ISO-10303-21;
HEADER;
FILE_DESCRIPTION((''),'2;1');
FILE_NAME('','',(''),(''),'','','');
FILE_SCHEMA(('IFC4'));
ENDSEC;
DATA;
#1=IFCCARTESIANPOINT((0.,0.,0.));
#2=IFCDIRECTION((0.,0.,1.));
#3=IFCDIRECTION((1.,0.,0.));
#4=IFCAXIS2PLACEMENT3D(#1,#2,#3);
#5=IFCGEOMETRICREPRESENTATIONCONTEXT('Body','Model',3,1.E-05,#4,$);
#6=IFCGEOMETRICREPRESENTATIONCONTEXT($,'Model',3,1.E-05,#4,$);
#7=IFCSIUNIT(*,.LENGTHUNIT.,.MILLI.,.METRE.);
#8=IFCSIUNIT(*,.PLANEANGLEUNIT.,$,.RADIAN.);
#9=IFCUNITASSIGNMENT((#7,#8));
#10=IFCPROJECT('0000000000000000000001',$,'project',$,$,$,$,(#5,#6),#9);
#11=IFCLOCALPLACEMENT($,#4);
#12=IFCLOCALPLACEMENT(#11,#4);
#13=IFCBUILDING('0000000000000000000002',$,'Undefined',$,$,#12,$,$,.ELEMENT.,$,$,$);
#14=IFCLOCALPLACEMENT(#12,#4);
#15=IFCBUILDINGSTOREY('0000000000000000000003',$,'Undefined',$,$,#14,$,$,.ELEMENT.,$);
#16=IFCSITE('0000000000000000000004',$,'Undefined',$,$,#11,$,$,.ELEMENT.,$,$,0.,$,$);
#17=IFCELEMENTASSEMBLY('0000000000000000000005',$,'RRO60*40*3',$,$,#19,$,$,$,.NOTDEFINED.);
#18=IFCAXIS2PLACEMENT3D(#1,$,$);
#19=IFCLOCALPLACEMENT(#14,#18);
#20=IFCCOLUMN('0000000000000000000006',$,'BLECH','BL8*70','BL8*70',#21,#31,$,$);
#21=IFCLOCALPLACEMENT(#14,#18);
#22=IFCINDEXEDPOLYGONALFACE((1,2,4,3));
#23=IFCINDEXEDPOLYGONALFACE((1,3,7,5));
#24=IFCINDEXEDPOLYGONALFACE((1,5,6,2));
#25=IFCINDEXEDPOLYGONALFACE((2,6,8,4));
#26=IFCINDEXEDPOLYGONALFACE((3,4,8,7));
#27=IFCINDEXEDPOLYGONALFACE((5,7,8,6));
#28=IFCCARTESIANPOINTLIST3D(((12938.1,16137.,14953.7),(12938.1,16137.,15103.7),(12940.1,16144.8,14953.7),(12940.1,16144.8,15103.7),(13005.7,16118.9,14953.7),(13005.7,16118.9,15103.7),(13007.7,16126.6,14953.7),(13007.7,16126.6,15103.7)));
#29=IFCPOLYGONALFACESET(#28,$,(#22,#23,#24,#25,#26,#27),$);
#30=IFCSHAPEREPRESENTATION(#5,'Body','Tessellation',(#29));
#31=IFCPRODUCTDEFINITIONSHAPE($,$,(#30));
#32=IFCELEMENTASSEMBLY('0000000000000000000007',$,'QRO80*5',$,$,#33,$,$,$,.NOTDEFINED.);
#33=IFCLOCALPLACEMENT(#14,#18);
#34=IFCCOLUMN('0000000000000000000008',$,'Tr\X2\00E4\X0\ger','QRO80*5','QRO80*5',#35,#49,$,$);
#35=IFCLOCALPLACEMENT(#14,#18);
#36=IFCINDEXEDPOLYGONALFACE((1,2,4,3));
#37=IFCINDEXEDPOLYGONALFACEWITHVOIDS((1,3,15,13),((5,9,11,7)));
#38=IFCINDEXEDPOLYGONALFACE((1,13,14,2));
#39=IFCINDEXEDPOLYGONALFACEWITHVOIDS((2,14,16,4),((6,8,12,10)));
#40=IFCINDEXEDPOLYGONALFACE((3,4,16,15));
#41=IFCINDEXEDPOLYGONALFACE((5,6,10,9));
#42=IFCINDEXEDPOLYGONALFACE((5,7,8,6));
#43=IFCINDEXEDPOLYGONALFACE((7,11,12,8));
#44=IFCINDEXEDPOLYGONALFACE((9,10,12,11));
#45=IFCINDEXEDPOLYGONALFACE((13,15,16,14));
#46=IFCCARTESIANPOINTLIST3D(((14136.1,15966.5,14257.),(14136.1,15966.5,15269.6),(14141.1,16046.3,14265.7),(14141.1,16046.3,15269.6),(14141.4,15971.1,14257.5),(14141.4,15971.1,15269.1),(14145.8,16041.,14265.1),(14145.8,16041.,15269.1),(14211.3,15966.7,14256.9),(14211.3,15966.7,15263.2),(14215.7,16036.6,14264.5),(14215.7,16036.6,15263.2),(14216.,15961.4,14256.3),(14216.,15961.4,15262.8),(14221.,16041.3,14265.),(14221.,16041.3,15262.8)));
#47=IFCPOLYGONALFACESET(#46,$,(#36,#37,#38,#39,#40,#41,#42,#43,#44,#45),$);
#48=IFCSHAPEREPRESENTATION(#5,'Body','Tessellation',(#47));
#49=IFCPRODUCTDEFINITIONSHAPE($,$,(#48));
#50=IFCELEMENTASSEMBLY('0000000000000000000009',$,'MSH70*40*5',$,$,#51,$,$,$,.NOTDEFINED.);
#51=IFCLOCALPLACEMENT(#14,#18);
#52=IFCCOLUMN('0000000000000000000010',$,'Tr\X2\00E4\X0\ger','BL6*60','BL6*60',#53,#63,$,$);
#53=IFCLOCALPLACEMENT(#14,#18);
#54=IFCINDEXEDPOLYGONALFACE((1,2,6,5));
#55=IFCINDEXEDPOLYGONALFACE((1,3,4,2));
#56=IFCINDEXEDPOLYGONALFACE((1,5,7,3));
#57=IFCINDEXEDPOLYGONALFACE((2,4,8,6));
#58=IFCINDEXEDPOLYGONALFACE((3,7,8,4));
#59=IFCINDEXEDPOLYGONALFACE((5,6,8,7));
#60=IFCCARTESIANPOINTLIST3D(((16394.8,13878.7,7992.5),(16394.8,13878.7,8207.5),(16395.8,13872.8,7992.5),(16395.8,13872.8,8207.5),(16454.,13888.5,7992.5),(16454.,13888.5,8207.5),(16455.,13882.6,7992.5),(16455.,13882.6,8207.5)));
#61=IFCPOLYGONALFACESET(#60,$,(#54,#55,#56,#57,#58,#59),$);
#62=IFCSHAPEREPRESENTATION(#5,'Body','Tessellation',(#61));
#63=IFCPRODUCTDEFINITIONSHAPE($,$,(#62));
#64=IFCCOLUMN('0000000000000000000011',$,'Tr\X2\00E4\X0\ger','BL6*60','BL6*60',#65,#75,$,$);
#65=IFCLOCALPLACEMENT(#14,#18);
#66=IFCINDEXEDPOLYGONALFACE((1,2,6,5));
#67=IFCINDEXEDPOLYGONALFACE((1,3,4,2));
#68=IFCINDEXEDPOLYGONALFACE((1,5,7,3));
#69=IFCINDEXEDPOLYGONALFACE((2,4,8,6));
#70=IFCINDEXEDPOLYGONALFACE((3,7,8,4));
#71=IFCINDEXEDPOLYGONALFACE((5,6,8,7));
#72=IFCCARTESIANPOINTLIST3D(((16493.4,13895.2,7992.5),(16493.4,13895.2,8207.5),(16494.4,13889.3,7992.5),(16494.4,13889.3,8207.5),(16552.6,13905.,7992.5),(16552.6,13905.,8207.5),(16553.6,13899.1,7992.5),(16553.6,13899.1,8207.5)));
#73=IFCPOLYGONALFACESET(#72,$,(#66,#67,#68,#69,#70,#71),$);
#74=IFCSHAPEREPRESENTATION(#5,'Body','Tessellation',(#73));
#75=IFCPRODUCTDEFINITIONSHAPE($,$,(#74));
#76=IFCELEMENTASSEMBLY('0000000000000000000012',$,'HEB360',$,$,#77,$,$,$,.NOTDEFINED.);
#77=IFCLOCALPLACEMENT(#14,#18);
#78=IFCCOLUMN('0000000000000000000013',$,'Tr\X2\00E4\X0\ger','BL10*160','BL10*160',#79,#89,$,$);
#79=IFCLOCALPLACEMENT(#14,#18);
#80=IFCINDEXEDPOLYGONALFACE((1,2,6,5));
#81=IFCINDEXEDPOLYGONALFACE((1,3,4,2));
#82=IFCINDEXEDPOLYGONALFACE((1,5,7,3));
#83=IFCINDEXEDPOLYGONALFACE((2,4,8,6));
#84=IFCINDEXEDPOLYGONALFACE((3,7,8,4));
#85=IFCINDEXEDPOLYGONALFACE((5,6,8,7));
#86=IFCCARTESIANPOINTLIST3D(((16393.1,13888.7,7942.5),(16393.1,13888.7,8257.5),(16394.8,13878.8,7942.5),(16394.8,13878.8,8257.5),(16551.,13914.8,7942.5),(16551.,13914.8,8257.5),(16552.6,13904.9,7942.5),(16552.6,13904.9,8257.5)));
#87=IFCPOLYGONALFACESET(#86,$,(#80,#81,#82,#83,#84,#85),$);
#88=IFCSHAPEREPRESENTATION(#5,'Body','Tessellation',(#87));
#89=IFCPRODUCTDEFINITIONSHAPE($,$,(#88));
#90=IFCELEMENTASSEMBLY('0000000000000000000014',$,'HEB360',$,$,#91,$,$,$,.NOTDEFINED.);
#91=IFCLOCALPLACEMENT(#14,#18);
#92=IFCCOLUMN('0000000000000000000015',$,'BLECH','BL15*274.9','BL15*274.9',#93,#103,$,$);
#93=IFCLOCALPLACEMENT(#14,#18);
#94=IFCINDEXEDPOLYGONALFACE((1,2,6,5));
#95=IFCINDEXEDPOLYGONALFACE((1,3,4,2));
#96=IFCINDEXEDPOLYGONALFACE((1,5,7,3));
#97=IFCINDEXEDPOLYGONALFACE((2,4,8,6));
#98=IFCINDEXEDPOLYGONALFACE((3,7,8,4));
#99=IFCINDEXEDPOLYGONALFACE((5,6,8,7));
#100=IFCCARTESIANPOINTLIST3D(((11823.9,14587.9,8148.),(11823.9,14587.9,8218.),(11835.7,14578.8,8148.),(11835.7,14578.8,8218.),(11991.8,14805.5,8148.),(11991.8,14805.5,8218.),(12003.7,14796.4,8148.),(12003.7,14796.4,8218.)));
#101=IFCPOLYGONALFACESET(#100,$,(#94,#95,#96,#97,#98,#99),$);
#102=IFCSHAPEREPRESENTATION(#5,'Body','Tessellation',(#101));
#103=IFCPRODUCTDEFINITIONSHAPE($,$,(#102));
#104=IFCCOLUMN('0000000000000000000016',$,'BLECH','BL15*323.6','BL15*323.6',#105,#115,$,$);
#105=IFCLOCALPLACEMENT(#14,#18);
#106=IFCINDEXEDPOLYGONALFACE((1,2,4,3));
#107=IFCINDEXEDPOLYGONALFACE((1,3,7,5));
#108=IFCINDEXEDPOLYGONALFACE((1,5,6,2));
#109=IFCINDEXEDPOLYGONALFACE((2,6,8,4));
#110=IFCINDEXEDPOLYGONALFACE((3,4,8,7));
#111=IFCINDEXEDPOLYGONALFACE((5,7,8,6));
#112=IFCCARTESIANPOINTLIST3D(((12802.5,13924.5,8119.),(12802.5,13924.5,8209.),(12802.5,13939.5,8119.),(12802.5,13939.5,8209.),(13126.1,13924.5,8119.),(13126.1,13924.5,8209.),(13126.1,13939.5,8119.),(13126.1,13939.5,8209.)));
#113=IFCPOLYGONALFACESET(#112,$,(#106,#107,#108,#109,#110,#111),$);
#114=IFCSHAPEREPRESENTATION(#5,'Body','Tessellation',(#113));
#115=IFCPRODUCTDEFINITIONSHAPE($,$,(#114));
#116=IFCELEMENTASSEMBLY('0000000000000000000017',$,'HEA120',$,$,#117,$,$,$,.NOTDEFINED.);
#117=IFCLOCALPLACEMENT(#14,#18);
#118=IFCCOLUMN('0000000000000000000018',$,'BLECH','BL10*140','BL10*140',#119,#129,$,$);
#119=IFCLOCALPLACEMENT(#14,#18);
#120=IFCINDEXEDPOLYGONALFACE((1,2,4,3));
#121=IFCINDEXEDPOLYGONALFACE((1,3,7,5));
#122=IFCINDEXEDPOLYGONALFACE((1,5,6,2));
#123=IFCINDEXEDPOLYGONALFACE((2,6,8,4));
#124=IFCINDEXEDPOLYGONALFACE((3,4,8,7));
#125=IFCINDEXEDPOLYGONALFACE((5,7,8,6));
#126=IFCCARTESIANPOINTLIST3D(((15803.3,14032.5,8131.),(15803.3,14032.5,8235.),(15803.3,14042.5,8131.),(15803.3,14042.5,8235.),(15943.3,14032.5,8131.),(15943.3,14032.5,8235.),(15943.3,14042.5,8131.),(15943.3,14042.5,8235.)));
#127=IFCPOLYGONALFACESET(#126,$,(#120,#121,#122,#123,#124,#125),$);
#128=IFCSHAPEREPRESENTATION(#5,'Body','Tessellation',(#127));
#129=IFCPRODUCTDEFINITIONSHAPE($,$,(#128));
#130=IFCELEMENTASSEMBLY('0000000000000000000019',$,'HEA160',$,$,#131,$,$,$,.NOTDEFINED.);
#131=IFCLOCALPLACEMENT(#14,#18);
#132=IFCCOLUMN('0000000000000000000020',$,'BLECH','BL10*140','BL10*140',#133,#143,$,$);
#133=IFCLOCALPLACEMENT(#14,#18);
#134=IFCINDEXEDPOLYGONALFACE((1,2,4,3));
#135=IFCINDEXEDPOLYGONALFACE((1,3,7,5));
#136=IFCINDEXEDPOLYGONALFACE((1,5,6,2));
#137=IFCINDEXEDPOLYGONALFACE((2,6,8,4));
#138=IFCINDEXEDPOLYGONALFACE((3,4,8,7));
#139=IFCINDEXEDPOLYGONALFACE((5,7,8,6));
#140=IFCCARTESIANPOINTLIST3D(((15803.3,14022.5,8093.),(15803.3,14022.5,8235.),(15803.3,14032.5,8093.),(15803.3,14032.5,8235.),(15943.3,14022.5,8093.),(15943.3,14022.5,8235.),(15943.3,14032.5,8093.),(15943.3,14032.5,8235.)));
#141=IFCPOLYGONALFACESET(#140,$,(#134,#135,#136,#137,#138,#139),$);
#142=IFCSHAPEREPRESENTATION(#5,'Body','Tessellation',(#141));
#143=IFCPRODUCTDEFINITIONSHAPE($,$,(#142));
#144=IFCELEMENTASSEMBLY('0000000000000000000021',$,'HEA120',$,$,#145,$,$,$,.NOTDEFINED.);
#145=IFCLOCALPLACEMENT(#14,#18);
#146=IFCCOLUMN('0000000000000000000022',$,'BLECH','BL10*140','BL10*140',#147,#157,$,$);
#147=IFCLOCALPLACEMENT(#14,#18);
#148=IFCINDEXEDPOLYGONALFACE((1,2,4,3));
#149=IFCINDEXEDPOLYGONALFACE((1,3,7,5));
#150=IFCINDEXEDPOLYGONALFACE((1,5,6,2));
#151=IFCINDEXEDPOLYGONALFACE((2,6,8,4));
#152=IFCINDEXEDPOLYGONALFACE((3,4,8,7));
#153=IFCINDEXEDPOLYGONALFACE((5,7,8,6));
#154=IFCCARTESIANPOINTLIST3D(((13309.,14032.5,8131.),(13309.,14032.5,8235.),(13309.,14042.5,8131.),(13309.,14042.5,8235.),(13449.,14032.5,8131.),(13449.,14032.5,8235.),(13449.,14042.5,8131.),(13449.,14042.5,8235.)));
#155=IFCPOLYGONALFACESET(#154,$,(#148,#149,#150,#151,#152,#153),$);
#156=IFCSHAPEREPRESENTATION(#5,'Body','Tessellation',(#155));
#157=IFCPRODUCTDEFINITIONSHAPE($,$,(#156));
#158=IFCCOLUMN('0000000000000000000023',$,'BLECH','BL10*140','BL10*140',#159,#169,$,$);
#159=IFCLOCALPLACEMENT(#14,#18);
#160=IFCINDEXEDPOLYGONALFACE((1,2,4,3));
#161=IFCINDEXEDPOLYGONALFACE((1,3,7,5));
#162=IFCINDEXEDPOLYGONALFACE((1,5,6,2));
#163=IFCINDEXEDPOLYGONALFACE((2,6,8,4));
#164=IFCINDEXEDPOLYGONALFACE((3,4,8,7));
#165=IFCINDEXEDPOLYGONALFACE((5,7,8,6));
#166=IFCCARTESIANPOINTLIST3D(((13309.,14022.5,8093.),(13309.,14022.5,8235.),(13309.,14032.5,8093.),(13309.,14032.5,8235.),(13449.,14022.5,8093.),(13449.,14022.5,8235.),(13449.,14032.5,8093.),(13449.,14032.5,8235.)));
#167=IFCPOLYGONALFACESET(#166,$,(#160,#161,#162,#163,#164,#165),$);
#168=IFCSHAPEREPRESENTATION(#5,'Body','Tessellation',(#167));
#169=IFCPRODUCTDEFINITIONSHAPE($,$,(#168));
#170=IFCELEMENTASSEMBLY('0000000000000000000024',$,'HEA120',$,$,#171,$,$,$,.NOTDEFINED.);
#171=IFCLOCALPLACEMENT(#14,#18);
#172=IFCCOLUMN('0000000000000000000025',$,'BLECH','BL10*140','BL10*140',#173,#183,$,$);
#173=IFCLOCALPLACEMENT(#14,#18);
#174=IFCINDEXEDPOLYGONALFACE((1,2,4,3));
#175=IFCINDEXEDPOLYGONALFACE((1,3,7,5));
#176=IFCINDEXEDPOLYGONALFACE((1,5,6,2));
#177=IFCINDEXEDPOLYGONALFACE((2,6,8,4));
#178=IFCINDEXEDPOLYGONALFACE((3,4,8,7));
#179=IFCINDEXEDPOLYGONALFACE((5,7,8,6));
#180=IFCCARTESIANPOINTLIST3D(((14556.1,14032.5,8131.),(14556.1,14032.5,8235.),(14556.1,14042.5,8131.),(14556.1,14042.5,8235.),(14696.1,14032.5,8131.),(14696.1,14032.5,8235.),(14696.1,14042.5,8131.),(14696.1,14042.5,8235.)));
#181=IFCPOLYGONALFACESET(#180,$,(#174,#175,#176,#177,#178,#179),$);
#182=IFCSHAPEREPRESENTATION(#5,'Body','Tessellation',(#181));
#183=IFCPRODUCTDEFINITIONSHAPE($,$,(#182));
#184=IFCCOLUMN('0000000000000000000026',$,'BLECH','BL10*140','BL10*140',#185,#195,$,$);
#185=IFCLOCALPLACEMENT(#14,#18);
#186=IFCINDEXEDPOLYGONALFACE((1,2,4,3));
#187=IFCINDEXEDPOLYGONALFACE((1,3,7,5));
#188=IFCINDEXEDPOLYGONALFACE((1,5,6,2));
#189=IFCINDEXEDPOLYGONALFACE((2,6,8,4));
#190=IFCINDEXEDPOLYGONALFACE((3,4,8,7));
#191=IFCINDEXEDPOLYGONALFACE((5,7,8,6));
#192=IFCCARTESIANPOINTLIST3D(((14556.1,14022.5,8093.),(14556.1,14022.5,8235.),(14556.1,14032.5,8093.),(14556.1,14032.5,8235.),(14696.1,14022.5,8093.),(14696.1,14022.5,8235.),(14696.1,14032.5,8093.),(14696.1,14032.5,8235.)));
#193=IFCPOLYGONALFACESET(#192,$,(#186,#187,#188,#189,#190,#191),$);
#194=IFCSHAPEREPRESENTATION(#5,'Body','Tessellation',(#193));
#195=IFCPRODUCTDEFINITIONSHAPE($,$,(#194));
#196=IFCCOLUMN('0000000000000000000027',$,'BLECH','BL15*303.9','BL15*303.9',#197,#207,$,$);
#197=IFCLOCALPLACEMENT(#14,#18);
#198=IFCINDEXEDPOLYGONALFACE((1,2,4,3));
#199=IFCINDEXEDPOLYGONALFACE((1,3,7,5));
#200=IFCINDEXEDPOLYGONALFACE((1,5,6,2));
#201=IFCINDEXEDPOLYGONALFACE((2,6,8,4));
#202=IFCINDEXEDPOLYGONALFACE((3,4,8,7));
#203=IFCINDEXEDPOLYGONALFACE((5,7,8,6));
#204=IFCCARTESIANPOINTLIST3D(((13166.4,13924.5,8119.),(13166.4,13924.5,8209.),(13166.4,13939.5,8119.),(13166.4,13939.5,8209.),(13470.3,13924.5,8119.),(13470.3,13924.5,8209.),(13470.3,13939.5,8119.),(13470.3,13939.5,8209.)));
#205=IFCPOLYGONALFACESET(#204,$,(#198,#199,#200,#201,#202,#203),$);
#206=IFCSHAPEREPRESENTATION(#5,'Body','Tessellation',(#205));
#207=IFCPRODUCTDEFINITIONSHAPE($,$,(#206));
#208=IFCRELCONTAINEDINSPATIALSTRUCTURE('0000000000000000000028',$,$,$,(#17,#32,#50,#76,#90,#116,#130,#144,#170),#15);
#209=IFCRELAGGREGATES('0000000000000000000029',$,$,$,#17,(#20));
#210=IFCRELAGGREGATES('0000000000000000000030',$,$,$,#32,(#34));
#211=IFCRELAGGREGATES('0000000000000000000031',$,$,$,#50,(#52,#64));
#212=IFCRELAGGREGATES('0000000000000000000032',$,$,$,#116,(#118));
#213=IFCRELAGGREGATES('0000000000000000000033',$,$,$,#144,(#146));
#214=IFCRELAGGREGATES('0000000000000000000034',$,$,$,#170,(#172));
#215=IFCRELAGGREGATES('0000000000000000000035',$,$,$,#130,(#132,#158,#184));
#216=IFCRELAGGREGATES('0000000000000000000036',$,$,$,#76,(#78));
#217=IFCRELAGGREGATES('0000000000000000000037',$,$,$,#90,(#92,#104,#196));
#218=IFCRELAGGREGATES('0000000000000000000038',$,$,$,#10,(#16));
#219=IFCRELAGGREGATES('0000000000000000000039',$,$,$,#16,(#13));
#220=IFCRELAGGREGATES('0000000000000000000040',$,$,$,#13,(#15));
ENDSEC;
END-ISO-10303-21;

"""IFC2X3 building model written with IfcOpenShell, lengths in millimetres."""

from ifc_helpers import new_model, si_unit, frame, origin_with_axes, origin_2d_with_axis, place, context, project, spatial, rectangle, hollow_rectangle, extrude, clip, halfspace, element, aggregate, save


model = new_model("IFC2X3")

# Units and contexts
model_context_1 = context("Model", 3, precision=1e-05, world=origin_with_axes(), identifier="Body")
model_context_2 = context("Model", 3, precision=1e-05, world=origin_with_axes())
ifc_project = project(units=[si_unit("LENGTHUNIT", "METRE", prefix="MILLI"), si_unit("PLANEANGLEUNIT", "RADIAN")], contexts=[model_context_1, model_context_2])

# Site, building, storey
site_placement = place(None, origin_with_axes())
site = spatial("IfcSite", under=ifc_project, at=site_placement, Name="Undefined", CompositionType="ELEMENT", RefElevation=0.0)
building_placement = place(site_placement, origin_with_axes())
building = spatial("IfcBuilding", under=site, at=building_placement, Name="Undefined", CompositionType="ELEMENT")
storey_placement = place(building_placement, origin_with_axes())
storey = spatial("IfcBuildingStorey", under=building, at=storey_placement, Name="Undefined", CompositionType="ELEMENT")

# Element assemblies, columns
assembly_1 = element("IfcElementAssembly", 1, inside=storey, Name="RRO60*40*3", PredefinedType="NOTDEFINED")
column_1_placement = place(storey_placement, frame((12972.9, 16131.8, 14953.7), z_axis=(0.0, 0.0, 1.0), x_axis=(1.0, 0.0, 0.0)))
column_1 = element("IfcColumn", 2, at=column_1_placement, Name="BLECH", Description="BL8*70", ObjectType="BL8*70", context=model_context_1, shape_type="SweptSolid", body=[
    extrude(rectangle(XDim=8.0, YDim=70.0, at=origin_2d_with_axis()), frame((0.0, 0.0, 150.0), z_axis=(0.0, 0.0, -1.0), x_axis=(0.259156, 0.965835, 0.000005)), (0.0, 0.0, 1.0), 150.0),
])
aggregate(assembly_1, [column_1])
assembly_2 = element("IfcElementAssembly", 3, inside=storey, Name="QRO80*5", PredefinedType="NOTDEFINED")
column_2_placement = place(storey_placement, frame((14178.6, 16003.9, 14430.9), z_axis=(0.0, 0.0, 1.0), x_axis=(1.0, 0.0, 0.0)))
column_2 = element("IfcColumn", 4, at=column_2_placement, Name="Träger", Description="QRO80*5", ObjectType="QRO80*5", context=model_context_1, shape_type="Clipping", body=[
    clip(clip(extrude(hollow_rectangle(XDim=80.0, YDim=80.0, WallThickness=5.0, at=origin_2d_with_axis()), frame((0.0, 0.0, 843.4), z_axis=(0.0, 0.0, -1.0), x_axis=(0.998019, -0.06291, -0.000001)), (0.0, 0.0, 1.0), 1021.5), halfspace(frame((39.9, -2.5, -170.3), z_axis=(0.001304, -0.108856, 0.994057), x_axis=(-0.063857, -0.992038, -0.108551)), True)), halfspace(frame((-2.5, -39.9, 835.2), z_axis=(-0.084763, 0.005352, -0.996387), x_axis=(0.994413, -0.062691, -0.084932)), True)),
])
aggregate(assembly_2, [column_2])

# Element assembly, columns
assembly_3 = element("IfcElementAssembly", 5, inside=storey, Name="MSH70*40*5", PredefinedType="NOTDEFINED")
column_3_placement = place(storey_placement, frame((16424.9, 13880.7, 7992.5), z_axis=(0.0, 0.0, 1.0), x_axis=(1.0, 0.0, 0.0)))
column_3 = element("IfcColumn", 6, at=column_3_placement, Name="Träger", Description="BL6*60", ObjectType="BL6*60", context=model_context_1, shape_type="SweptSolid", body=[
    extrude(rectangle(XDim=6.0, YDim=60.0, at=origin_2d_with_axis()), frame((0.0, 0.0, 215.0), z_axis=(0.0, 0.0, -1.0), x_axis=(0.163326, -0.986572, 0.0)), (0.0, 0.0, 1.0), 215.0),
])
column_4_placement = place(storey_placement, frame((16523.5, 13897.1, 7992.5), z_axis=(0.0, 0.0, 1.0), x_axis=(1.0, 0.0, 0.0)))
column_4 = element("IfcColumn", 7, at=column_4_placement, Name="Träger", Description="BL6*60", ObjectType="BL6*60", context=model_context_1, shape_type="SweptSolid", body=[
    extrude(rectangle(XDim=6.0, YDim=60.0, at=origin_2d_with_axis()), frame((0.0, 0.0, 215.0), z_axis=(0.0, 0.0, -1.0), x_axis=(0.163326, -0.986572, 0.0)), (0.0, 0.0, 1.0), 215.0),
])
aggregate(assembly_3, [column_3, column_4])

# Element assembly, column
assembly_4 = element("IfcElementAssembly", 8, inside=storey, Name="HEB360", PredefinedType="NOTDEFINED")
column_5_placement = place(storey_placement, frame((16472.9, 13896.8, 7942.5), z_axis=(0.0, 0.0, 1.0), x_axis=(1.0, 0.0, 0.0)))
column_5 = element("IfcColumn", 9, at=column_5_placement, Name="Träger", Description="BL10*160", ObjectType="BL10*160", context=model_context_1, shape_type="SweptSolid", body=[
    extrude(rectangle(XDim=10.0, YDim=160.0, at=origin_2d_with_axis()), frame((0.0, 0.0, 315.0), z_axis=(0.0, 0.0, -1.0), x_axis=(0.163326, -0.986572, 0.0)), (0.0, 0.0, 1.0), 315.0),
])

# Element assembly, columns
assembly_5 = element("IfcElementAssembly", 10, inside=storey, Name="HEB360", PredefinedType="NOTDEFINED")
column_6_placement = place(storey_placement, frame((11913.8, 14692.1, 8148.0), z_axis=(0.0, 0.0, 1.0), x_axis=(1.0, 0.0, 0.0)))
column_6 = element("IfcColumn", 11, at=column_6_placement, Name="BLECH", Description="BL15*274.9", ObjectType="BL15*274.9", context=model_context_1, shape_type="SweptSolid", body=[
    extrude(rectangle(XDim=15.0, YDim=274.9, at=origin_2d_with_axis()), frame((0.0, 0.0, 70.0), z_axis=(0.0, 0.0, -1.0), x_axis=(-0.791596, 0.611045, 0.0)), (0.0, 0.0, 1.0), 70.0),
])
column_7_placement = place(storey_placement, frame((12964.3, 13932.0, 8119.0), z_axis=(0.0, 0.0, 1.0), x_axis=(1.0, 0.0, 0.0)))
column_7 = element("IfcColumn", 12, at=column_7_placement, Name="BLECH", Description="BL15*323.6", ObjectType="BL15*323.6", context=model_context_1, shape_type="SweptSolid", body=[
    extrude(rectangle(XDim=15.0, YDim=323.6, at=origin_2d_with_axis()), frame((0.0, 0.0, 90.0), z_axis=(0.0, 0.0, -1.0), x_axis=(0.0, 1.0, 0.0)), (0.0, 0.0, 1.0), 90.0),
])

# Element assemblies, columns
assembly_6 = element("IfcElementAssembly", 13, inside=storey, Name="HEA120", PredefinedType="NOTDEFINED")
column_8_placement = place(storey_placement, frame((15873.3, 14037.5, 8131.0), z_axis=(0.0, 0.0, 1.0), x_axis=(1.0, 0.0, 0.0)))
column_8 = element("IfcColumn", 14, at=column_8_placement, Name="BLECH", Description="BL10*140", ObjectType="BL10*140", context=model_context_1, shape_type="SweptSolid", body=[
    extrude(rectangle(XDim=10.0, YDim=140.0, at=origin_2d_with_axis()), frame((0.0, 0.0, 104.0), z_axis=(0.0, 0.0, -1.0), x_axis=(0.0, 1.0, 0.0)), (0.0, 0.0, 1.0), 104.0),
])
aggregate(assembly_6, [column_8])
assembly_7 = element("IfcElementAssembly", 15, inside=storey, Name="HEA160", PredefinedType="NOTDEFINED")
column_9_placement = place(storey_placement, frame((15873.3, 14027.5, 8093.0), z_axis=(0.0, 0.0, 1.0), x_axis=(1.0, 0.0, 0.0)))
column_9 = element("IfcColumn", 16, at=column_9_placement, Name="BLECH", Description="BL10*140", ObjectType="BL10*140", context=model_context_1, shape_type="SweptSolid", body=[
    extrude(rectangle(XDim=10.0, YDim=140.0, at=origin_2d_with_axis()), frame((0.0, 0.0, 142.0), z_axis=(0.0, 0.0, -1.0), x_axis=(0.0, 1.0, 0.0)), (0.0, 0.0, 1.0), 142.0),
])
assembly_8 = element("IfcElementAssembly", 17, inside=storey, Name="HEA120", PredefinedType="NOTDEFINED")
column_10_placement = place(storey_placement, frame((13379.0, 14037.5, 8131.0), z_axis=(0.0, 0.0, 1.0), x_axis=(1.0, 0.0, 0.0)))
column_10 = element("IfcColumn", 18, at=column_10_placement, Name="BLECH", Description="BL10*140", ObjectType="BL10*140", context=model_context_1, shape_type="SweptSolid", body=[
    extrude(rectangle(XDim=10.0, YDim=140.0, at=origin_2d_with_axis()), frame((0.0, 0.0, 104.0), z_axis=(0.0, 0.0, -1.0), x_axis=(0.0, 1.0, 0.0)), (0.0, 0.0, 1.0), 104.0),
])
aggregate(assembly_8, [column_10])

# Column
column_11_placement = place(storey_placement, frame((13379.0, 14027.5, 8093.0), z_axis=(0.0, 0.0, 1.0), x_axis=(1.0, 0.0, 0.0)))
column_11 = element("IfcColumn", 19, at=column_11_placement, Name="BLECH", Description="BL10*140", ObjectType="BL10*140", context=model_context_1, shape_type="SweptSolid", body=[
    extrude(rectangle(XDim=10.0, YDim=140.0, at=origin_2d_with_axis()), frame((0.0, 0.0, 142.0), z_axis=(0.0, 0.0, -1.0), x_axis=(0.0, 1.0, 0.0)), (0.0, 0.0, 1.0), 142.0),
])

# Element assembly, column
assembly_9 = element("IfcElementAssembly", 20, inside=storey, Name="HEA120", PredefinedType="NOTDEFINED")
column_12_placement = place(storey_placement, frame((14626.1, 14037.5, 8131.0), z_axis=(0.0, 0.0, 1.0), x_axis=(1.0, 0.0, 0.0)))
column_12 = element("IfcColumn", 21, at=column_12_placement, Name="BLECH", Description="BL10*140", ObjectType="BL10*140", context=model_context_1, shape_type="SweptSolid", body=[
    extrude(rectangle(XDim=10.0, YDim=140.0, at=origin_2d_with_axis()), frame((0.0, 0.0, 104.0), z_axis=(0.0, 0.0, -1.0), x_axis=(0.0, 1.0, 0.0)), (0.0, 0.0, 1.0), 104.0),
])
aggregate(assembly_9, [column_12])

# Columns
column_13_placement = place(storey_placement, frame((14626.1, 14027.5, 8093.0), z_axis=(0.0, 0.0, 1.0), x_axis=(1.0, 0.0, 0.0)))
column_13 = element("IfcColumn", 22, at=column_13_placement, Name="BLECH", Description="BL10*140", ObjectType="BL10*140", context=model_context_1, shape_type="SweptSolid", body=[
    extrude(rectangle(XDim=10.0, YDim=140.0, at=origin_2d_with_axis()), frame((0.0, 0.0, 142.0), z_axis=(0.0, 0.0, -1.0), x_axis=(0.0, 1.0, 0.0)), (0.0, 0.0, 1.0), 142.0),
])
aggregate(assembly_7, [column_9, column_11, column_13])
column_14_placement = place(storey_placement, frame((13318.3, 13932.0, 8119.0), z_axis=(0.0, 0.0, 1.0), x_axis=(1.0, 0.0, 0.0)))
column_14 = element("IfcColumn", 23, at=column_14_placement, Name="BLECH", Description="BL15*303.9", ObjectType="BL15*303.9", context=model_context_1, shape_type="SweptSolid", body=[
    extrude(rectangle(XDim=15.0, YDim=303.9, at=origin_2d_with_axis()), frame((0.0, 0.0, 90.0), z_axis=(0.0, 0.0, -1.0), x_axis=(0.0, -1.0, 0.0)), (0.0, 0.0, 1.0), 90.0),
])
aggregate(assembly_4, [column_5])
aggregate(assembly_5, [column_6, column_7, column_14])

save(model, "model.ifc")
